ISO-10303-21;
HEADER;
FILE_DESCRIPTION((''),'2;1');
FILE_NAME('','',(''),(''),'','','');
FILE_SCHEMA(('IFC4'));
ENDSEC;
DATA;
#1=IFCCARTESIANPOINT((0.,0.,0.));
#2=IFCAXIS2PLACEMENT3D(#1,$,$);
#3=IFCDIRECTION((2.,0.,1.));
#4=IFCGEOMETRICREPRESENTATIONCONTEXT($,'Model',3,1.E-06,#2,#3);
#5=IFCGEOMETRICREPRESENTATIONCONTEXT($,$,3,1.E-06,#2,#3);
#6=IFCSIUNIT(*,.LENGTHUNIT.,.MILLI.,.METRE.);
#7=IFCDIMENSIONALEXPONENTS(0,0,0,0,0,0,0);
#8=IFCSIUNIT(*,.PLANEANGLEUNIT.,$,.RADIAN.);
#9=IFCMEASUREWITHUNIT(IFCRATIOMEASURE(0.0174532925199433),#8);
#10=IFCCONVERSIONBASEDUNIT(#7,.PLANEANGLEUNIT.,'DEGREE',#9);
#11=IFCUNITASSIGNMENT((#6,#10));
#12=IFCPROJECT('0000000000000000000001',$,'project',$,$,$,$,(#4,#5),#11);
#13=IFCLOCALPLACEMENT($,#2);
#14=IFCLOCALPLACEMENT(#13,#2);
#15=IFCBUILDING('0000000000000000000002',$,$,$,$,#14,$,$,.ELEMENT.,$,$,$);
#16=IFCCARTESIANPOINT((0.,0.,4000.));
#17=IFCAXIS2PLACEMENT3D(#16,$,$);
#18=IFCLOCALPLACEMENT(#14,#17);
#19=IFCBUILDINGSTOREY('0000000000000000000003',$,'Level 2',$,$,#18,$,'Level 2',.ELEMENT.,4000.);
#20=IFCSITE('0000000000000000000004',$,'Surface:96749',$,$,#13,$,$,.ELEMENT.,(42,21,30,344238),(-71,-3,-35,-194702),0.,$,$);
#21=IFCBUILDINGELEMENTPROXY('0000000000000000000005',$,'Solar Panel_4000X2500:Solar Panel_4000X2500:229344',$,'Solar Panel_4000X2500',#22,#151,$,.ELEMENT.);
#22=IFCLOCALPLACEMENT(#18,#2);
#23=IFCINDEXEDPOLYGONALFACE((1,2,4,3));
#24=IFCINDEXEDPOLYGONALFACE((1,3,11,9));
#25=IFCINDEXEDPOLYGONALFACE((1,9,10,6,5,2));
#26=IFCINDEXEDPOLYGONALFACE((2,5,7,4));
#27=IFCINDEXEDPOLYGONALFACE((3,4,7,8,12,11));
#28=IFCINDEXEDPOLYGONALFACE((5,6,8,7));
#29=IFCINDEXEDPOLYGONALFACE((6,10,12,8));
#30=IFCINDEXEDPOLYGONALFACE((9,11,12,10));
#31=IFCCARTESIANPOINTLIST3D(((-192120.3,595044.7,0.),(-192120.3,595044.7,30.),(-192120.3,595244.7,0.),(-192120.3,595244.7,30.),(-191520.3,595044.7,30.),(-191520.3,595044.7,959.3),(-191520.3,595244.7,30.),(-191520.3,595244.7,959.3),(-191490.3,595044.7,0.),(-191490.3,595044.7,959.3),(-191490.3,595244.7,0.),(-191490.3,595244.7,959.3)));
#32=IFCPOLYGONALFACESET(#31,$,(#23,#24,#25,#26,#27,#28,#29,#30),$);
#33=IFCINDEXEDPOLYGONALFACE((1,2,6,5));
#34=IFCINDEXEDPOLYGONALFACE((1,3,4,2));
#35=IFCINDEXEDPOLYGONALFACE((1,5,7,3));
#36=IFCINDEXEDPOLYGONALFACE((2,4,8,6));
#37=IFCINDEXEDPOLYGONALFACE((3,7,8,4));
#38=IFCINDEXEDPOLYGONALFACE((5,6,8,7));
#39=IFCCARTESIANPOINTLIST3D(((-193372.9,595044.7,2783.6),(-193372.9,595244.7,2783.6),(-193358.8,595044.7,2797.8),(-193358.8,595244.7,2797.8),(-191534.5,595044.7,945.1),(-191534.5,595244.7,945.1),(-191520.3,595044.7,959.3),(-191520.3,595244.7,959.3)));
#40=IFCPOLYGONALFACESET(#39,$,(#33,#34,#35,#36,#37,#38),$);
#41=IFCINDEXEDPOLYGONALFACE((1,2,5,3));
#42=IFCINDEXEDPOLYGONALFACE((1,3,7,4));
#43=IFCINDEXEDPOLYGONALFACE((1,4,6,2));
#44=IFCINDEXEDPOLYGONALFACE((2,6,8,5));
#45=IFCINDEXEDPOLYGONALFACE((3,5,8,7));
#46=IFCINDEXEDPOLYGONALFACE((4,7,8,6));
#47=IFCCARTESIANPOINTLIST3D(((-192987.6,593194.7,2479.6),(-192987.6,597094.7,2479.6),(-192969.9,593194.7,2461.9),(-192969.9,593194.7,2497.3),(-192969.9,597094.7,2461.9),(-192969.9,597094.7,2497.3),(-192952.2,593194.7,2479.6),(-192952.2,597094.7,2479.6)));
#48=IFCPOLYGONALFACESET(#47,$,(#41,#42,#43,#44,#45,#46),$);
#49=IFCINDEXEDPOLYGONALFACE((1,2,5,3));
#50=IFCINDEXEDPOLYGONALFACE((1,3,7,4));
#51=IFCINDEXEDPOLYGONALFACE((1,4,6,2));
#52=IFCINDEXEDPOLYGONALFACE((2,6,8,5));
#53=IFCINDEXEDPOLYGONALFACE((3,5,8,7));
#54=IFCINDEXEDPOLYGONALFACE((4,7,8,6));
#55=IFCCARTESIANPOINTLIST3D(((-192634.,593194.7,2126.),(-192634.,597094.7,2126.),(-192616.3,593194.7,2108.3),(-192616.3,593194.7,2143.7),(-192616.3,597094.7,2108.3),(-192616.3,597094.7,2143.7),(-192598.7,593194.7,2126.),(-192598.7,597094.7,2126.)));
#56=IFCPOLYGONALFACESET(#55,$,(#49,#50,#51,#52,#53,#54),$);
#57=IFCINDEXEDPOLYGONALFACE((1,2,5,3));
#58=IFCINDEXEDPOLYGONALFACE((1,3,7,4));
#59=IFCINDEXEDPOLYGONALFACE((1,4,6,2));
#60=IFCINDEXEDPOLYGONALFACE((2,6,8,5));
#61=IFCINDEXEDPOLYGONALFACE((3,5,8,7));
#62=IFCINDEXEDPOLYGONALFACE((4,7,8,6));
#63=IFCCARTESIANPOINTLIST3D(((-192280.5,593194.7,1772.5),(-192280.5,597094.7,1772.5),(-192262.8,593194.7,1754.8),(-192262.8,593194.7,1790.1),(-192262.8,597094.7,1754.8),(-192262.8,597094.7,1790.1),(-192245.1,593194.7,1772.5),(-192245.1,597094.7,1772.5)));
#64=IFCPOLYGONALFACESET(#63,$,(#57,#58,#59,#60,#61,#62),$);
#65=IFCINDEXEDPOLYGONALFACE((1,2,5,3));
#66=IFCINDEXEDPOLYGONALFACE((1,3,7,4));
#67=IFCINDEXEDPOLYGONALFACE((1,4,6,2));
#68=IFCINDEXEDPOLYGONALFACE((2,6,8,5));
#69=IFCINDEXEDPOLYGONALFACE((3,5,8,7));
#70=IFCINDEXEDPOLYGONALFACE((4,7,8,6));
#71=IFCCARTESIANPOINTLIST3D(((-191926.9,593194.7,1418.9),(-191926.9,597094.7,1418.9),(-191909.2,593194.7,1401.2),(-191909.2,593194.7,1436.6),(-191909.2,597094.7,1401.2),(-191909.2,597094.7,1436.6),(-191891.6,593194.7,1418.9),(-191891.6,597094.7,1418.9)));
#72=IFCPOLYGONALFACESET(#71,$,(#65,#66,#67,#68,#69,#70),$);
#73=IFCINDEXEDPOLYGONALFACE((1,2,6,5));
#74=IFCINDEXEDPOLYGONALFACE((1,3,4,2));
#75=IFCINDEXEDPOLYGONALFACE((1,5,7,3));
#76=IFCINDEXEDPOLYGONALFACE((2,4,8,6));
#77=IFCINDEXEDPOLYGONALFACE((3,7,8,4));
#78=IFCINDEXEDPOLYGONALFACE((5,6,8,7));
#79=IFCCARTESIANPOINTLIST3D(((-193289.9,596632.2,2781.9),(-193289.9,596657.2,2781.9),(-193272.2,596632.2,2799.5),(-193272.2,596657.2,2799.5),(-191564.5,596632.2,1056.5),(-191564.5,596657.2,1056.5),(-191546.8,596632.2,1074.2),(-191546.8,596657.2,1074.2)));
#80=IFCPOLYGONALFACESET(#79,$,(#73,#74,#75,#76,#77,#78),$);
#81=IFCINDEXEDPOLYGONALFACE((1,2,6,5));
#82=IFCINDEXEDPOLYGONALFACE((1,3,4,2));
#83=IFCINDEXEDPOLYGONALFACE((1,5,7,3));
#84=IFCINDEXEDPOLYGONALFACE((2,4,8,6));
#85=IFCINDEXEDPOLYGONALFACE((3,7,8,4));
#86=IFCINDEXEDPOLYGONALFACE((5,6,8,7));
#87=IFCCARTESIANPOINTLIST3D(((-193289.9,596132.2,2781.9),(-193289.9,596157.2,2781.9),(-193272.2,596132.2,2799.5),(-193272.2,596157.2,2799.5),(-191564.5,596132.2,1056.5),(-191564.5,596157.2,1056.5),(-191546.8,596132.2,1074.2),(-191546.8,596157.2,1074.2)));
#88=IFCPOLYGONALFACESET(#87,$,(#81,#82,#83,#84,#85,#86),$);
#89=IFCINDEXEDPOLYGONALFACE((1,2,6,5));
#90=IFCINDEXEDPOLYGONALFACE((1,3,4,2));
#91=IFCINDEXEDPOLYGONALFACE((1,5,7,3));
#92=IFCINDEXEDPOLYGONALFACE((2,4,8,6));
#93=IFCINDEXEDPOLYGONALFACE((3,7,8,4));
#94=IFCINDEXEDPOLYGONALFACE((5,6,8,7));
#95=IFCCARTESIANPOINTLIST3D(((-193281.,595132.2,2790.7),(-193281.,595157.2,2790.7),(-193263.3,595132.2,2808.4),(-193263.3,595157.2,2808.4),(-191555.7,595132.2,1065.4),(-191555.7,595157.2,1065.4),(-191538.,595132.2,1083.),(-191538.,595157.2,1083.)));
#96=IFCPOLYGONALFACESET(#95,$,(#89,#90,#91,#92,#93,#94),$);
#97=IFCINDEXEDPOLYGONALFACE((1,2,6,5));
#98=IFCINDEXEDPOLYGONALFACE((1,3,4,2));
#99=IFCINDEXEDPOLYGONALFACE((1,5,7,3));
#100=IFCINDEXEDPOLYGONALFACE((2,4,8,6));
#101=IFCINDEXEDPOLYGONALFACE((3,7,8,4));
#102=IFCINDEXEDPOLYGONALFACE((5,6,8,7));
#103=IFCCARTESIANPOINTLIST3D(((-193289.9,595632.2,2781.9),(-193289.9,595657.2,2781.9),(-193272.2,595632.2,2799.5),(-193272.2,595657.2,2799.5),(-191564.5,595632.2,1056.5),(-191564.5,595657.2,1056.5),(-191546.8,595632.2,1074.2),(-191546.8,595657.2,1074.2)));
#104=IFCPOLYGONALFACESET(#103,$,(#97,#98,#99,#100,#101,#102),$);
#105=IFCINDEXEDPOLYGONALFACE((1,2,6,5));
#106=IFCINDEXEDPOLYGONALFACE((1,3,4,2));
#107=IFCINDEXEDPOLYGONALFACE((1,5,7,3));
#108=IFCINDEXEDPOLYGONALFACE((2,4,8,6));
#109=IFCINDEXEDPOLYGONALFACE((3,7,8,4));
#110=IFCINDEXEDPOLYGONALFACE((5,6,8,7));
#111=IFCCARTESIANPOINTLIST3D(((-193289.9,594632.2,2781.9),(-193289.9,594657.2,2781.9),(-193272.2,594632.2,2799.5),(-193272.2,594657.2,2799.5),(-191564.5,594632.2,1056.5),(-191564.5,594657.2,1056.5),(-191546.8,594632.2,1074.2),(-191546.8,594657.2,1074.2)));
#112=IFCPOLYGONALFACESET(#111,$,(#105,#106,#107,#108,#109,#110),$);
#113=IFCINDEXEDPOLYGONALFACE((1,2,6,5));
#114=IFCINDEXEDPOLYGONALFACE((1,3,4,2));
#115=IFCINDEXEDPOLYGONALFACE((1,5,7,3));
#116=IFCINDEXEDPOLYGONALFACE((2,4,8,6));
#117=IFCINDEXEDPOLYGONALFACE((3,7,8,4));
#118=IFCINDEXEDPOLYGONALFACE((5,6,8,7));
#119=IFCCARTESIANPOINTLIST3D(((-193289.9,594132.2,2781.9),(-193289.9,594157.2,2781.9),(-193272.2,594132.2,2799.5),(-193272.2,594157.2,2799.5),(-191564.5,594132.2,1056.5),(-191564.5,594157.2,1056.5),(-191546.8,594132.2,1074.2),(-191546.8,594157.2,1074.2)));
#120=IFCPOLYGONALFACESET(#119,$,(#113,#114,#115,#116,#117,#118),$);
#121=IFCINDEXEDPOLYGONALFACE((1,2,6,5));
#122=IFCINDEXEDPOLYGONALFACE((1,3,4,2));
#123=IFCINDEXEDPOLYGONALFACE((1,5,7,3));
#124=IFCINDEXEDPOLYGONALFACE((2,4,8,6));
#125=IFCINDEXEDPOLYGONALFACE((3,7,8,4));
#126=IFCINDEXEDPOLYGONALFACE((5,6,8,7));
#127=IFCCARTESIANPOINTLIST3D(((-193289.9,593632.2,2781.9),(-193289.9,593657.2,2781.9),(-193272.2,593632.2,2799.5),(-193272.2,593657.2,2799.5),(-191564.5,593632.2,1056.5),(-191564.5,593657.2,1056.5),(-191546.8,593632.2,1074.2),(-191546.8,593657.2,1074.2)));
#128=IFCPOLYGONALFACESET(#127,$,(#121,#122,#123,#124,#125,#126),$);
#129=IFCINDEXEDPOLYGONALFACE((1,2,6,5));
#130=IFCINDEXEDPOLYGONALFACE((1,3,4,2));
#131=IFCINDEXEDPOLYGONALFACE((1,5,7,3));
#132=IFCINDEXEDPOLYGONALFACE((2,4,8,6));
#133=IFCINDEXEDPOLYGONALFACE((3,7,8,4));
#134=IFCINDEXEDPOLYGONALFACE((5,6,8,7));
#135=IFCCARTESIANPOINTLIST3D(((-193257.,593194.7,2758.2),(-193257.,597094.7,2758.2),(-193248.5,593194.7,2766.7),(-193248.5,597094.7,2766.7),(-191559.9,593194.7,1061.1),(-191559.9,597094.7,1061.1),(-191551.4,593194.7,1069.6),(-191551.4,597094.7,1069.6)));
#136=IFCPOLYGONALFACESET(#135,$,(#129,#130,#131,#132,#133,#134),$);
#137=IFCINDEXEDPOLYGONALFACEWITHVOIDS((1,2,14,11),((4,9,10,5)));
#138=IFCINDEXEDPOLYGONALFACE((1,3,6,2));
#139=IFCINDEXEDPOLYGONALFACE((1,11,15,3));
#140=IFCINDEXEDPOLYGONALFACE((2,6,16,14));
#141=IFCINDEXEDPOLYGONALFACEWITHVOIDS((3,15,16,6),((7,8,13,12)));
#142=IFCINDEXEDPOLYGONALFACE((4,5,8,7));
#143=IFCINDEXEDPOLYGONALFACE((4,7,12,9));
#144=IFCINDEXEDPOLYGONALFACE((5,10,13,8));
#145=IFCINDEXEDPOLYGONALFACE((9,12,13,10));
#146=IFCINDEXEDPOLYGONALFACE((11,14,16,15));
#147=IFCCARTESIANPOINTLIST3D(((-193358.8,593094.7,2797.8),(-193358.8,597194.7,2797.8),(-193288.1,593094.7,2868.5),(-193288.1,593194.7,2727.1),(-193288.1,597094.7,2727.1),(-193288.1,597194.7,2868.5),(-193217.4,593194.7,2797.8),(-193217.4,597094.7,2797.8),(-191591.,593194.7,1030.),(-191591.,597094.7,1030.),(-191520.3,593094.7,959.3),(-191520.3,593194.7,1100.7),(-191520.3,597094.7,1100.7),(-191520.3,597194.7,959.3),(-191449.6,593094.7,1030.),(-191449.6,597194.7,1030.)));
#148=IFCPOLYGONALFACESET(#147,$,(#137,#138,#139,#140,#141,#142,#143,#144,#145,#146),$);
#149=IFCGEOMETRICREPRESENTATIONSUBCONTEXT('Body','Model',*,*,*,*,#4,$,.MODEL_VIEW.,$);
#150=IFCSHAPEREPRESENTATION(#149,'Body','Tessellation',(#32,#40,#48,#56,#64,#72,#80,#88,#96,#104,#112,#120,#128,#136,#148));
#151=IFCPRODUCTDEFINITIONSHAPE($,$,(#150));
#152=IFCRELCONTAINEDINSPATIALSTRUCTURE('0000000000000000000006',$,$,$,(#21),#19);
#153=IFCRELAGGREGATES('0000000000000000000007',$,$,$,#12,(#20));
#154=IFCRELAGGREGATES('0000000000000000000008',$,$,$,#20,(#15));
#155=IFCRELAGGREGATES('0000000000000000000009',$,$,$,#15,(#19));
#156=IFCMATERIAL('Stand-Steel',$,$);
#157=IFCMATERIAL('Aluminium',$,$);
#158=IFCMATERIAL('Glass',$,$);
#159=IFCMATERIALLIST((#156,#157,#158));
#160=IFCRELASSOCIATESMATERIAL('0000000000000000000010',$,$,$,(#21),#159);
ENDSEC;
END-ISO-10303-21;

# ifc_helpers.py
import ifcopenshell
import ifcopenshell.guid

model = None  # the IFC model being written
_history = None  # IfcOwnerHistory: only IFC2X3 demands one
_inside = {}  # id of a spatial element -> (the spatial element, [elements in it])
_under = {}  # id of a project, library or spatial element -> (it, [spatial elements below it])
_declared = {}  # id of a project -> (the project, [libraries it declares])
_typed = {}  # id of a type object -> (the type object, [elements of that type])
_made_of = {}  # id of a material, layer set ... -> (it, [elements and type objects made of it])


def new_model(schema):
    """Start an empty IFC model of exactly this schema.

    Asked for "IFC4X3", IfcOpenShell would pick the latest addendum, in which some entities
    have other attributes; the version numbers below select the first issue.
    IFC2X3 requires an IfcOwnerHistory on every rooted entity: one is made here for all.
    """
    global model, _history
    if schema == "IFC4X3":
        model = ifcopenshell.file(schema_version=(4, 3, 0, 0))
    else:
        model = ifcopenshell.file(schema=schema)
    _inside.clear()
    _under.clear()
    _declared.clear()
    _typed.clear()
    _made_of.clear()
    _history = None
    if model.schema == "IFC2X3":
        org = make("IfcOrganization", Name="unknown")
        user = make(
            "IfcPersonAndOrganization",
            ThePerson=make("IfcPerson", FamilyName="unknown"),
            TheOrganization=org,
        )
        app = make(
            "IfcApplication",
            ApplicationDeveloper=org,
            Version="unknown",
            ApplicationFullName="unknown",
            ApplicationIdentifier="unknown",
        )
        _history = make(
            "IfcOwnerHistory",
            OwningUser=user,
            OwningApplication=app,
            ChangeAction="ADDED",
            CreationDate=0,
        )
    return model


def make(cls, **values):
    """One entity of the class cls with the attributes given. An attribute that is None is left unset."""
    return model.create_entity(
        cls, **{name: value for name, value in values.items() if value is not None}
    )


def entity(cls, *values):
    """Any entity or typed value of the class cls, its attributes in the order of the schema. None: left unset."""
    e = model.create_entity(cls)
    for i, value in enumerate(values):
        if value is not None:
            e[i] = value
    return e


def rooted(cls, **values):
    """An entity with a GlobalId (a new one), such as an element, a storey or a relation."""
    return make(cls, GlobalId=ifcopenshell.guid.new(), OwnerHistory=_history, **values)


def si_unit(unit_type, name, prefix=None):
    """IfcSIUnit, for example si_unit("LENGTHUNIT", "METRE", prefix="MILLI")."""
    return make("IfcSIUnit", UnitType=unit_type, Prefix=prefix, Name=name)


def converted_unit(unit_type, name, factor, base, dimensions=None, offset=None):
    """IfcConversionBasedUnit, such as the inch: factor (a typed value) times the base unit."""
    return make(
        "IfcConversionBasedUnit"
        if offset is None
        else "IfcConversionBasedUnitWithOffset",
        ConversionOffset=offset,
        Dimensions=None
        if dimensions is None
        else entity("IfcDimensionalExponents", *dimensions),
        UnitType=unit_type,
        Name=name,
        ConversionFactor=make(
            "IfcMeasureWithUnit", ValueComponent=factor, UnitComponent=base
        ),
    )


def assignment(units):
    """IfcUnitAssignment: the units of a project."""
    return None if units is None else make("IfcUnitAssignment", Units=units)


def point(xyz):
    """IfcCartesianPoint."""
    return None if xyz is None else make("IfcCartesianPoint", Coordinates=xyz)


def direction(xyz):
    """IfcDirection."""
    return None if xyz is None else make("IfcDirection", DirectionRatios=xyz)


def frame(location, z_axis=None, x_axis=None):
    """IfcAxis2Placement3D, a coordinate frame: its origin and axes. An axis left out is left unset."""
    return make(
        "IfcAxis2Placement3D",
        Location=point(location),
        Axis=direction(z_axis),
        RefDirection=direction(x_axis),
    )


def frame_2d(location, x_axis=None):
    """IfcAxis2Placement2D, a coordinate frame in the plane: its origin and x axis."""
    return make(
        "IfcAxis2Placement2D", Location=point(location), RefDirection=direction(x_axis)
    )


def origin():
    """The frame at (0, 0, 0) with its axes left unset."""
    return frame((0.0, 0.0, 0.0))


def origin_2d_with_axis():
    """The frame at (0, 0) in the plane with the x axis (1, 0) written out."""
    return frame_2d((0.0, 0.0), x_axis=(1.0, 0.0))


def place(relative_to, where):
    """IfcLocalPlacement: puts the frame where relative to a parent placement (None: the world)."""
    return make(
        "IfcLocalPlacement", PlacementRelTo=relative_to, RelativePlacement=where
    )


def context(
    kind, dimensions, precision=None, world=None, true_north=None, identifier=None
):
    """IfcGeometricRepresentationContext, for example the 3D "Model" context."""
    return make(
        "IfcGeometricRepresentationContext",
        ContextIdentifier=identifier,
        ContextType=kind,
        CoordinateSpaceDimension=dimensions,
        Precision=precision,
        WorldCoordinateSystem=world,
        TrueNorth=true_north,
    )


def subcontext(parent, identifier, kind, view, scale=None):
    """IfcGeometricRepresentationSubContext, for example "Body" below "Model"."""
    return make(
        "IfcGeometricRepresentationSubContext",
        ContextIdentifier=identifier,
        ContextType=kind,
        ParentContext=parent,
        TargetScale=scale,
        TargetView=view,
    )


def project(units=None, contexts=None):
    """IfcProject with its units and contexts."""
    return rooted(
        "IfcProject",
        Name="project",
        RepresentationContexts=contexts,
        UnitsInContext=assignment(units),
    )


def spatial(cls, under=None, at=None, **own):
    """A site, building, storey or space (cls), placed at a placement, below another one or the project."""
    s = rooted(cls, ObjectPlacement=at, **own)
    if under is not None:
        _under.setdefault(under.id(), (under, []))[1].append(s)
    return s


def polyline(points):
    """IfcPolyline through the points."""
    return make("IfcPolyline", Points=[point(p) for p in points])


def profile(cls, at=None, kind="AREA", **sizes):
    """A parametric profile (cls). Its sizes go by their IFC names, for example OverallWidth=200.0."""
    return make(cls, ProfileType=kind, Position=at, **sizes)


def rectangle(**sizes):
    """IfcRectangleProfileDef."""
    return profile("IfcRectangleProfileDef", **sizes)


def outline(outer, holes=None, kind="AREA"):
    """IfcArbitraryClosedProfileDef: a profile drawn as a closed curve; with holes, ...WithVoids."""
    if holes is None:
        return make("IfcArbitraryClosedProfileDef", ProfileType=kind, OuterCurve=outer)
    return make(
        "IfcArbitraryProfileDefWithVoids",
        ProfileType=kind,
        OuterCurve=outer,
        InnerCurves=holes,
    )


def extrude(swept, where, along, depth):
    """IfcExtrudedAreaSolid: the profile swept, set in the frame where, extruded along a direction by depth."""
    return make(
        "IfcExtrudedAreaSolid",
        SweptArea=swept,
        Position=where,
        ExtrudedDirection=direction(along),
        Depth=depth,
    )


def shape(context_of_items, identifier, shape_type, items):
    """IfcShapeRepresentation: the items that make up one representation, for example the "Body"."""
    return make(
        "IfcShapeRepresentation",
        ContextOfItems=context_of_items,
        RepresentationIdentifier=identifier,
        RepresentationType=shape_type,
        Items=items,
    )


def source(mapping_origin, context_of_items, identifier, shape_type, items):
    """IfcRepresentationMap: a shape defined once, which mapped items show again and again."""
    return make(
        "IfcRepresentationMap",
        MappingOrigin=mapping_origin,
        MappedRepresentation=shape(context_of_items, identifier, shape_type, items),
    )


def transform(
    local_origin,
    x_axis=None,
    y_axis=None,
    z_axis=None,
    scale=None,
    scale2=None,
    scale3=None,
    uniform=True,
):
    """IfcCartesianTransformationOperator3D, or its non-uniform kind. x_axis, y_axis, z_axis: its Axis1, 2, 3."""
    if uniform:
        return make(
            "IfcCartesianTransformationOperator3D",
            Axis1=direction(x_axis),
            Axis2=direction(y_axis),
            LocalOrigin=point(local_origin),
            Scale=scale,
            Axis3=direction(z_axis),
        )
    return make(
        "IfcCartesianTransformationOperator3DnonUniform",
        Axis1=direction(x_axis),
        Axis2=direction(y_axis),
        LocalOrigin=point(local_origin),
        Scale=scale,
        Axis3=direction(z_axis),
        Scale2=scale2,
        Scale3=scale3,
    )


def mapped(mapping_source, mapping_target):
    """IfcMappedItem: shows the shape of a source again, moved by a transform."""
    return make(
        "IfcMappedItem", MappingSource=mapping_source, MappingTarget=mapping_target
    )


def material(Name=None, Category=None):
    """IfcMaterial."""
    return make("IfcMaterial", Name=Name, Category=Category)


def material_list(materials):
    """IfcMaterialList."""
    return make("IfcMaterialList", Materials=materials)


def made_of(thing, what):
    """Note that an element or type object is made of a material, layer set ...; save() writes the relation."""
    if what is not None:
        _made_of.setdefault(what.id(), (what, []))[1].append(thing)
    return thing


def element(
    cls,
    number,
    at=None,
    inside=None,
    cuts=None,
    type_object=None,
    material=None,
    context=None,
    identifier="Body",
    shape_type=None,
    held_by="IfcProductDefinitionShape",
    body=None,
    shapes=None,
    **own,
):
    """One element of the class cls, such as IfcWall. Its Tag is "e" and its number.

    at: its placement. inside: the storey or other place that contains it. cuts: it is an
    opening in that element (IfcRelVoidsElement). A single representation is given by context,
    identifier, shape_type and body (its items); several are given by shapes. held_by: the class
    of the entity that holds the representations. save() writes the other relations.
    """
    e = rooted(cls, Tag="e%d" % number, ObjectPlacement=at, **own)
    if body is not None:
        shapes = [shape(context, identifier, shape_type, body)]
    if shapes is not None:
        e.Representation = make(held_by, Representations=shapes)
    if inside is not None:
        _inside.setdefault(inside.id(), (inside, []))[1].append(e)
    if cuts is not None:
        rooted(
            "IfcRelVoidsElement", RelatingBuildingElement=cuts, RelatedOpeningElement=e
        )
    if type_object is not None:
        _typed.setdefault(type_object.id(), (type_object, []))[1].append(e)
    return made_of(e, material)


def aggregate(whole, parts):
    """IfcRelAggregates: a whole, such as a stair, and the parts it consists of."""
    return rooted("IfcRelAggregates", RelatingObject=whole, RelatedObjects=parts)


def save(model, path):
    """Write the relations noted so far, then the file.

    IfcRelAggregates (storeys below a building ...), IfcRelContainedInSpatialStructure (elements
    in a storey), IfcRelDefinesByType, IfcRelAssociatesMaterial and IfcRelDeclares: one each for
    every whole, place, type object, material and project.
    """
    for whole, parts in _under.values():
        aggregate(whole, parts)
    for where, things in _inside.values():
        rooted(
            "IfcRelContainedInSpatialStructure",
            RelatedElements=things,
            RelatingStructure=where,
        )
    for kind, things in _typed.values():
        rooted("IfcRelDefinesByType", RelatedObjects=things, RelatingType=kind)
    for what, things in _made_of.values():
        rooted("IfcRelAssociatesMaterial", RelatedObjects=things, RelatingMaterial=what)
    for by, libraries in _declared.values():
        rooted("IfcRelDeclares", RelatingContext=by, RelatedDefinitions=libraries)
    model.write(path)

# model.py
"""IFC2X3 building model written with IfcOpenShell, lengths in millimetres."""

from ifc_helpers import new_model, entity, si_unit, converted_unit, direction, frame, frame_2d, origin, origin_2d_with_axis, place, context, subcontext, project, spatial, polyline, rectangle, outline, extrude, source, transform, mapped, material, material_list, element, save


model = new_model("IFC2X3")

# Units and contexts
model_context = context("Model", 3, precision=1e-06, world=origin(), true_north=direction((2.0, 0.0, 1.0)))
context_of_model = context(None, 3, precision=1e-06, world=origin(), true_north=direction((2.0, 0.0, 1.0)))
body_context = subcontext(model_context, "Body", "Model", "MODEL_VIEW")
ifc_project = project(units=[si_unit("LENGTHUNIT", "METRE", prefix="MILLI"), converted_unit("PLANEANGLEUNIT", "DEGREE", entity("IfcRatioMeasure", 0.0174532925199433), si_unit("PLANEANGLEUNIT", "RADIAN"), dimensions=[0, 0, 0, 0, 0, 0, 0])], contexts=[model_context, context_of_model])

# Site, building, storey
site_placement = place(None, origin())
site = spatial("IfcSite", under=ifc_project, at=site_placement, Name="Surface:96749", CompositionType="ELEMENT", RefLatitude=(42, 21, 30, 344238), RefLongitude=(-71, -3, -35, -194702), RefElevation=0.0)
building_placement = place(site_placement, origin())
building = spatial("IfcBuilding", under=site, at=building_placement, CompositionType="ELEMENT")
storey_placement = place(building_placement, frame((0.0, 0.0, 4000.0)))
storey = spatial("IfcBuildingStorey", under=building, at=storey_placement, Name="Level 2", LongName="Level 2", CompositionType="ELEMENT", Elevation=4000.0)

# Building element proxy
ifc_material_1 = material(Name="Stand-Steel")
ifc_material_2 = material(Name="Aluminium")
ifc_material_3 = material(Name="Glass")
shared_shape = source(origin(), body_context, "Body", "SweptSolid", [
    extrude(outline(polyline([(-629.5, -220.0), (329.8, -220.0), (329.8, 410.0), (299.8, 410.0), (299.8, -190.0), (-629.5, -190.0), (-629.5, -220.0)])), frame((-190.0, -100.0, 299.8), z_axis=(0.0, 1.0, 0.0), x_axis=(0.0, 0.0, -1.0)), (0.0, 0.0, 1.0), 200.0),
    extrude(rectangle(XDim=20.0, YDim=200.0, at=frame_2d((0.0, 0.0), x_axis=(0.0, 1.0))), frame((-7.1, 0.0, 922.2), z_axis=(-0.707107, 0.0, 0.707107), x_axis=(0.0, 1.0, 0.0)), (0.0, 0.0, 1.0), 2600.0),
    extrude(rectangle(XDim=25.0, YDim=25.0, at=frame_2d((0.0, 0.0), x_axis=(1.0, 0.0))), frame((-1449.6, -1950.0, 2449.6), z_axis=(0.0, 1.0, 0.0), x_axis=(-0.707107, 0.0, -0.707107)), (0.0, 0.0, 1.0), 3900.0),
    extrude(rectangle(XDim=25.0, YDim=25.0, at=origin_2d_with_axis()), frame((-1096.0, -1950.0, 2096.0), z_axis=(0.0, 1.0, 0.0), x_axis=(-0.707107, 0.0, -0.707107)), (0.0, 0.0, 1.0), 3900.0),
    extrude(rectangle(XDim=25.0, YDim=25.0, at=origin_2d_with_axis()), frame((-742.5, -1950.0, 1742.5), z_axis=(0.0, 1.0, 0.0), x_axis=(-0.707107, 0.0, -0.707107)), (0.0, 0.0, 1.0), 3900.0),
    extrude(rectangle(XDim=25.0, YDim=25.0, at=frame_2d((0.0, 0.0), x_axis=(1.0, 0.0))), frame((-388.9, -1950.0, 1388.9), z_axis=(0.0, 1.0, 0.0), x_axis=(-0.707107, 0.0, -0.707107)), (0.0, 0.0, 1.0), 3900.0),
    extrude(rectangle(XDim=25.0, YDim=25.0, at=frame_2d((0.0, 0.0), x_axis=(0.0, 1.0))), frame((-35.4, 1500.0, 1035.4), z_axis=(-0.707107, 0.0, 0.707107), x_axis=(0.0, 1.0, 0.0)), (0.0, 0.0, 1.0), 2440.0),
    extrude(rectangle(XDim=25.0, YDim=25.0, at=frame_2d((0.0, 0.0), x_axis=(0.0, 1.0))), frame((-35.4, 1000.0, 1035.4), z_axis=(-0.707107, 0.0, 0.707107), x_axis=(0.0, 1.0, 0.0)), (0.0, 0.0, 1.0), 2440.0),
    extrude(rectangle(XDim=25.0, YDim=25.0, at=frame_2d((0.0, 0.0), x_axis=(0.0, 1.0))), frame((-26.5, 0.0, 1044.2), z_axis=(-0.707107, 0.0, 0.707107), x_axis=(0.0, -1.0, 0.0)), (0.0, 0.0, 1.0), 2440.0),
    extrude(rectangle(XDim=25.0, YDim=25.0, at=frame_2d((0.0, 0.0), x_axis=(0.0, 1.0))), frame((-35.4, 500.0, 1035.4), z_axis=(-0.707107, 0.0, 0.707107), x_axis=(0.0, 1.0, 0.0)), (0.0, 0.0, 1.0), 2440.0),
    extrude(rectangle(XDim=25.0, YDim=25.0, at=frame_2d((0.0, 0.0), x_axis=(0.0, 1.0))), frame((-35.4, -500.0, 1035.4), z_axis=(-0.707107, 0.0, 0.707107), x_axis=(0.0, 1.0, 0.0)), (0.0, 0.0, 1.0), 2440.0),
    extrude(rectangle(XDim=25.0, YDim=25.0, at=frame_2d((0.0, 0.0), x_axis=(0.0, 1.0))), frame((-35.4, -1000.0, 1035.4), z_axis=(-0.707107, 0.0, 0.707107), x_axis=(0.0, 1.0, 0.0)), (0.0, 0.0, 1.0), 2440.0),
    extrude(rectangle(XDim=25.0, YDim=25.0, at=frame_2d((0.0, 0.0), x_axis=(0.0, 1.0))), frame((-35.4, -1500.0, 1035.4), z_axis=(-0.707107, 0.0, 0.707107), x_axis=(0.0, 1.0, 0.0)), (0.0, 0.0, 1.0), 2440.0),
    extrude(rectangle(XDim=2400.0, YDim=12.0, at=frame_2d((0.0, 0.0), x_axis=(1.0, 0.0))), frame((-883.9, -1950.0, 1883.9), z_axis=(0.0, 1.0, 0.0), x_axis=(0.707107, 0.0, -0.707107)), (0.0, 0.0, 1.0), 3900.0),
    extrude(outline(polyline([(-2050.0, -1300.0), (2050.0, -1300.0), (2050.0, 1300.0), (-2050.0, 1300.0), (-2050.0, -1300.0)]), holes=[polyline([(1950.0, -1200.0), (-1950.0, -1200.0), (-1950.0, 1200.0), (1950.0, 1200.0), (1950.0, -1200.0)])]), frame((-919.2, 0.0, 1848.5), z_axis=(0.707107, 0.0, 0.707107), x_axis=(0.0, 1.0, 0.0)), (0.0, 0.0, 1.0), 100.0),
])
ifc_material_list_1 = material_list([ifc_material_1, ifc_material_2, ifc_material_3])
proxy_1_placement = place(storey_placement, frame((-191520.3, 595144.7, 30.0)))
element("IfcBuildingElementProxy", 1, at=proxy_1_placement, inside=storey, material=ifc_material_list_1, Name="Solar Panel_4000X2500:Solar Panel_4000X2500:229344", ObjectType="Solar Panel_4000X2500", CompositionType="ELEMENT", context=body_context, shape_type="MappedRepresentation", body=[
    mapped(shared_shape, transform((0.0, 0.0, 0.0), scale=1.0)),
])

save(model, "model.ifc")
